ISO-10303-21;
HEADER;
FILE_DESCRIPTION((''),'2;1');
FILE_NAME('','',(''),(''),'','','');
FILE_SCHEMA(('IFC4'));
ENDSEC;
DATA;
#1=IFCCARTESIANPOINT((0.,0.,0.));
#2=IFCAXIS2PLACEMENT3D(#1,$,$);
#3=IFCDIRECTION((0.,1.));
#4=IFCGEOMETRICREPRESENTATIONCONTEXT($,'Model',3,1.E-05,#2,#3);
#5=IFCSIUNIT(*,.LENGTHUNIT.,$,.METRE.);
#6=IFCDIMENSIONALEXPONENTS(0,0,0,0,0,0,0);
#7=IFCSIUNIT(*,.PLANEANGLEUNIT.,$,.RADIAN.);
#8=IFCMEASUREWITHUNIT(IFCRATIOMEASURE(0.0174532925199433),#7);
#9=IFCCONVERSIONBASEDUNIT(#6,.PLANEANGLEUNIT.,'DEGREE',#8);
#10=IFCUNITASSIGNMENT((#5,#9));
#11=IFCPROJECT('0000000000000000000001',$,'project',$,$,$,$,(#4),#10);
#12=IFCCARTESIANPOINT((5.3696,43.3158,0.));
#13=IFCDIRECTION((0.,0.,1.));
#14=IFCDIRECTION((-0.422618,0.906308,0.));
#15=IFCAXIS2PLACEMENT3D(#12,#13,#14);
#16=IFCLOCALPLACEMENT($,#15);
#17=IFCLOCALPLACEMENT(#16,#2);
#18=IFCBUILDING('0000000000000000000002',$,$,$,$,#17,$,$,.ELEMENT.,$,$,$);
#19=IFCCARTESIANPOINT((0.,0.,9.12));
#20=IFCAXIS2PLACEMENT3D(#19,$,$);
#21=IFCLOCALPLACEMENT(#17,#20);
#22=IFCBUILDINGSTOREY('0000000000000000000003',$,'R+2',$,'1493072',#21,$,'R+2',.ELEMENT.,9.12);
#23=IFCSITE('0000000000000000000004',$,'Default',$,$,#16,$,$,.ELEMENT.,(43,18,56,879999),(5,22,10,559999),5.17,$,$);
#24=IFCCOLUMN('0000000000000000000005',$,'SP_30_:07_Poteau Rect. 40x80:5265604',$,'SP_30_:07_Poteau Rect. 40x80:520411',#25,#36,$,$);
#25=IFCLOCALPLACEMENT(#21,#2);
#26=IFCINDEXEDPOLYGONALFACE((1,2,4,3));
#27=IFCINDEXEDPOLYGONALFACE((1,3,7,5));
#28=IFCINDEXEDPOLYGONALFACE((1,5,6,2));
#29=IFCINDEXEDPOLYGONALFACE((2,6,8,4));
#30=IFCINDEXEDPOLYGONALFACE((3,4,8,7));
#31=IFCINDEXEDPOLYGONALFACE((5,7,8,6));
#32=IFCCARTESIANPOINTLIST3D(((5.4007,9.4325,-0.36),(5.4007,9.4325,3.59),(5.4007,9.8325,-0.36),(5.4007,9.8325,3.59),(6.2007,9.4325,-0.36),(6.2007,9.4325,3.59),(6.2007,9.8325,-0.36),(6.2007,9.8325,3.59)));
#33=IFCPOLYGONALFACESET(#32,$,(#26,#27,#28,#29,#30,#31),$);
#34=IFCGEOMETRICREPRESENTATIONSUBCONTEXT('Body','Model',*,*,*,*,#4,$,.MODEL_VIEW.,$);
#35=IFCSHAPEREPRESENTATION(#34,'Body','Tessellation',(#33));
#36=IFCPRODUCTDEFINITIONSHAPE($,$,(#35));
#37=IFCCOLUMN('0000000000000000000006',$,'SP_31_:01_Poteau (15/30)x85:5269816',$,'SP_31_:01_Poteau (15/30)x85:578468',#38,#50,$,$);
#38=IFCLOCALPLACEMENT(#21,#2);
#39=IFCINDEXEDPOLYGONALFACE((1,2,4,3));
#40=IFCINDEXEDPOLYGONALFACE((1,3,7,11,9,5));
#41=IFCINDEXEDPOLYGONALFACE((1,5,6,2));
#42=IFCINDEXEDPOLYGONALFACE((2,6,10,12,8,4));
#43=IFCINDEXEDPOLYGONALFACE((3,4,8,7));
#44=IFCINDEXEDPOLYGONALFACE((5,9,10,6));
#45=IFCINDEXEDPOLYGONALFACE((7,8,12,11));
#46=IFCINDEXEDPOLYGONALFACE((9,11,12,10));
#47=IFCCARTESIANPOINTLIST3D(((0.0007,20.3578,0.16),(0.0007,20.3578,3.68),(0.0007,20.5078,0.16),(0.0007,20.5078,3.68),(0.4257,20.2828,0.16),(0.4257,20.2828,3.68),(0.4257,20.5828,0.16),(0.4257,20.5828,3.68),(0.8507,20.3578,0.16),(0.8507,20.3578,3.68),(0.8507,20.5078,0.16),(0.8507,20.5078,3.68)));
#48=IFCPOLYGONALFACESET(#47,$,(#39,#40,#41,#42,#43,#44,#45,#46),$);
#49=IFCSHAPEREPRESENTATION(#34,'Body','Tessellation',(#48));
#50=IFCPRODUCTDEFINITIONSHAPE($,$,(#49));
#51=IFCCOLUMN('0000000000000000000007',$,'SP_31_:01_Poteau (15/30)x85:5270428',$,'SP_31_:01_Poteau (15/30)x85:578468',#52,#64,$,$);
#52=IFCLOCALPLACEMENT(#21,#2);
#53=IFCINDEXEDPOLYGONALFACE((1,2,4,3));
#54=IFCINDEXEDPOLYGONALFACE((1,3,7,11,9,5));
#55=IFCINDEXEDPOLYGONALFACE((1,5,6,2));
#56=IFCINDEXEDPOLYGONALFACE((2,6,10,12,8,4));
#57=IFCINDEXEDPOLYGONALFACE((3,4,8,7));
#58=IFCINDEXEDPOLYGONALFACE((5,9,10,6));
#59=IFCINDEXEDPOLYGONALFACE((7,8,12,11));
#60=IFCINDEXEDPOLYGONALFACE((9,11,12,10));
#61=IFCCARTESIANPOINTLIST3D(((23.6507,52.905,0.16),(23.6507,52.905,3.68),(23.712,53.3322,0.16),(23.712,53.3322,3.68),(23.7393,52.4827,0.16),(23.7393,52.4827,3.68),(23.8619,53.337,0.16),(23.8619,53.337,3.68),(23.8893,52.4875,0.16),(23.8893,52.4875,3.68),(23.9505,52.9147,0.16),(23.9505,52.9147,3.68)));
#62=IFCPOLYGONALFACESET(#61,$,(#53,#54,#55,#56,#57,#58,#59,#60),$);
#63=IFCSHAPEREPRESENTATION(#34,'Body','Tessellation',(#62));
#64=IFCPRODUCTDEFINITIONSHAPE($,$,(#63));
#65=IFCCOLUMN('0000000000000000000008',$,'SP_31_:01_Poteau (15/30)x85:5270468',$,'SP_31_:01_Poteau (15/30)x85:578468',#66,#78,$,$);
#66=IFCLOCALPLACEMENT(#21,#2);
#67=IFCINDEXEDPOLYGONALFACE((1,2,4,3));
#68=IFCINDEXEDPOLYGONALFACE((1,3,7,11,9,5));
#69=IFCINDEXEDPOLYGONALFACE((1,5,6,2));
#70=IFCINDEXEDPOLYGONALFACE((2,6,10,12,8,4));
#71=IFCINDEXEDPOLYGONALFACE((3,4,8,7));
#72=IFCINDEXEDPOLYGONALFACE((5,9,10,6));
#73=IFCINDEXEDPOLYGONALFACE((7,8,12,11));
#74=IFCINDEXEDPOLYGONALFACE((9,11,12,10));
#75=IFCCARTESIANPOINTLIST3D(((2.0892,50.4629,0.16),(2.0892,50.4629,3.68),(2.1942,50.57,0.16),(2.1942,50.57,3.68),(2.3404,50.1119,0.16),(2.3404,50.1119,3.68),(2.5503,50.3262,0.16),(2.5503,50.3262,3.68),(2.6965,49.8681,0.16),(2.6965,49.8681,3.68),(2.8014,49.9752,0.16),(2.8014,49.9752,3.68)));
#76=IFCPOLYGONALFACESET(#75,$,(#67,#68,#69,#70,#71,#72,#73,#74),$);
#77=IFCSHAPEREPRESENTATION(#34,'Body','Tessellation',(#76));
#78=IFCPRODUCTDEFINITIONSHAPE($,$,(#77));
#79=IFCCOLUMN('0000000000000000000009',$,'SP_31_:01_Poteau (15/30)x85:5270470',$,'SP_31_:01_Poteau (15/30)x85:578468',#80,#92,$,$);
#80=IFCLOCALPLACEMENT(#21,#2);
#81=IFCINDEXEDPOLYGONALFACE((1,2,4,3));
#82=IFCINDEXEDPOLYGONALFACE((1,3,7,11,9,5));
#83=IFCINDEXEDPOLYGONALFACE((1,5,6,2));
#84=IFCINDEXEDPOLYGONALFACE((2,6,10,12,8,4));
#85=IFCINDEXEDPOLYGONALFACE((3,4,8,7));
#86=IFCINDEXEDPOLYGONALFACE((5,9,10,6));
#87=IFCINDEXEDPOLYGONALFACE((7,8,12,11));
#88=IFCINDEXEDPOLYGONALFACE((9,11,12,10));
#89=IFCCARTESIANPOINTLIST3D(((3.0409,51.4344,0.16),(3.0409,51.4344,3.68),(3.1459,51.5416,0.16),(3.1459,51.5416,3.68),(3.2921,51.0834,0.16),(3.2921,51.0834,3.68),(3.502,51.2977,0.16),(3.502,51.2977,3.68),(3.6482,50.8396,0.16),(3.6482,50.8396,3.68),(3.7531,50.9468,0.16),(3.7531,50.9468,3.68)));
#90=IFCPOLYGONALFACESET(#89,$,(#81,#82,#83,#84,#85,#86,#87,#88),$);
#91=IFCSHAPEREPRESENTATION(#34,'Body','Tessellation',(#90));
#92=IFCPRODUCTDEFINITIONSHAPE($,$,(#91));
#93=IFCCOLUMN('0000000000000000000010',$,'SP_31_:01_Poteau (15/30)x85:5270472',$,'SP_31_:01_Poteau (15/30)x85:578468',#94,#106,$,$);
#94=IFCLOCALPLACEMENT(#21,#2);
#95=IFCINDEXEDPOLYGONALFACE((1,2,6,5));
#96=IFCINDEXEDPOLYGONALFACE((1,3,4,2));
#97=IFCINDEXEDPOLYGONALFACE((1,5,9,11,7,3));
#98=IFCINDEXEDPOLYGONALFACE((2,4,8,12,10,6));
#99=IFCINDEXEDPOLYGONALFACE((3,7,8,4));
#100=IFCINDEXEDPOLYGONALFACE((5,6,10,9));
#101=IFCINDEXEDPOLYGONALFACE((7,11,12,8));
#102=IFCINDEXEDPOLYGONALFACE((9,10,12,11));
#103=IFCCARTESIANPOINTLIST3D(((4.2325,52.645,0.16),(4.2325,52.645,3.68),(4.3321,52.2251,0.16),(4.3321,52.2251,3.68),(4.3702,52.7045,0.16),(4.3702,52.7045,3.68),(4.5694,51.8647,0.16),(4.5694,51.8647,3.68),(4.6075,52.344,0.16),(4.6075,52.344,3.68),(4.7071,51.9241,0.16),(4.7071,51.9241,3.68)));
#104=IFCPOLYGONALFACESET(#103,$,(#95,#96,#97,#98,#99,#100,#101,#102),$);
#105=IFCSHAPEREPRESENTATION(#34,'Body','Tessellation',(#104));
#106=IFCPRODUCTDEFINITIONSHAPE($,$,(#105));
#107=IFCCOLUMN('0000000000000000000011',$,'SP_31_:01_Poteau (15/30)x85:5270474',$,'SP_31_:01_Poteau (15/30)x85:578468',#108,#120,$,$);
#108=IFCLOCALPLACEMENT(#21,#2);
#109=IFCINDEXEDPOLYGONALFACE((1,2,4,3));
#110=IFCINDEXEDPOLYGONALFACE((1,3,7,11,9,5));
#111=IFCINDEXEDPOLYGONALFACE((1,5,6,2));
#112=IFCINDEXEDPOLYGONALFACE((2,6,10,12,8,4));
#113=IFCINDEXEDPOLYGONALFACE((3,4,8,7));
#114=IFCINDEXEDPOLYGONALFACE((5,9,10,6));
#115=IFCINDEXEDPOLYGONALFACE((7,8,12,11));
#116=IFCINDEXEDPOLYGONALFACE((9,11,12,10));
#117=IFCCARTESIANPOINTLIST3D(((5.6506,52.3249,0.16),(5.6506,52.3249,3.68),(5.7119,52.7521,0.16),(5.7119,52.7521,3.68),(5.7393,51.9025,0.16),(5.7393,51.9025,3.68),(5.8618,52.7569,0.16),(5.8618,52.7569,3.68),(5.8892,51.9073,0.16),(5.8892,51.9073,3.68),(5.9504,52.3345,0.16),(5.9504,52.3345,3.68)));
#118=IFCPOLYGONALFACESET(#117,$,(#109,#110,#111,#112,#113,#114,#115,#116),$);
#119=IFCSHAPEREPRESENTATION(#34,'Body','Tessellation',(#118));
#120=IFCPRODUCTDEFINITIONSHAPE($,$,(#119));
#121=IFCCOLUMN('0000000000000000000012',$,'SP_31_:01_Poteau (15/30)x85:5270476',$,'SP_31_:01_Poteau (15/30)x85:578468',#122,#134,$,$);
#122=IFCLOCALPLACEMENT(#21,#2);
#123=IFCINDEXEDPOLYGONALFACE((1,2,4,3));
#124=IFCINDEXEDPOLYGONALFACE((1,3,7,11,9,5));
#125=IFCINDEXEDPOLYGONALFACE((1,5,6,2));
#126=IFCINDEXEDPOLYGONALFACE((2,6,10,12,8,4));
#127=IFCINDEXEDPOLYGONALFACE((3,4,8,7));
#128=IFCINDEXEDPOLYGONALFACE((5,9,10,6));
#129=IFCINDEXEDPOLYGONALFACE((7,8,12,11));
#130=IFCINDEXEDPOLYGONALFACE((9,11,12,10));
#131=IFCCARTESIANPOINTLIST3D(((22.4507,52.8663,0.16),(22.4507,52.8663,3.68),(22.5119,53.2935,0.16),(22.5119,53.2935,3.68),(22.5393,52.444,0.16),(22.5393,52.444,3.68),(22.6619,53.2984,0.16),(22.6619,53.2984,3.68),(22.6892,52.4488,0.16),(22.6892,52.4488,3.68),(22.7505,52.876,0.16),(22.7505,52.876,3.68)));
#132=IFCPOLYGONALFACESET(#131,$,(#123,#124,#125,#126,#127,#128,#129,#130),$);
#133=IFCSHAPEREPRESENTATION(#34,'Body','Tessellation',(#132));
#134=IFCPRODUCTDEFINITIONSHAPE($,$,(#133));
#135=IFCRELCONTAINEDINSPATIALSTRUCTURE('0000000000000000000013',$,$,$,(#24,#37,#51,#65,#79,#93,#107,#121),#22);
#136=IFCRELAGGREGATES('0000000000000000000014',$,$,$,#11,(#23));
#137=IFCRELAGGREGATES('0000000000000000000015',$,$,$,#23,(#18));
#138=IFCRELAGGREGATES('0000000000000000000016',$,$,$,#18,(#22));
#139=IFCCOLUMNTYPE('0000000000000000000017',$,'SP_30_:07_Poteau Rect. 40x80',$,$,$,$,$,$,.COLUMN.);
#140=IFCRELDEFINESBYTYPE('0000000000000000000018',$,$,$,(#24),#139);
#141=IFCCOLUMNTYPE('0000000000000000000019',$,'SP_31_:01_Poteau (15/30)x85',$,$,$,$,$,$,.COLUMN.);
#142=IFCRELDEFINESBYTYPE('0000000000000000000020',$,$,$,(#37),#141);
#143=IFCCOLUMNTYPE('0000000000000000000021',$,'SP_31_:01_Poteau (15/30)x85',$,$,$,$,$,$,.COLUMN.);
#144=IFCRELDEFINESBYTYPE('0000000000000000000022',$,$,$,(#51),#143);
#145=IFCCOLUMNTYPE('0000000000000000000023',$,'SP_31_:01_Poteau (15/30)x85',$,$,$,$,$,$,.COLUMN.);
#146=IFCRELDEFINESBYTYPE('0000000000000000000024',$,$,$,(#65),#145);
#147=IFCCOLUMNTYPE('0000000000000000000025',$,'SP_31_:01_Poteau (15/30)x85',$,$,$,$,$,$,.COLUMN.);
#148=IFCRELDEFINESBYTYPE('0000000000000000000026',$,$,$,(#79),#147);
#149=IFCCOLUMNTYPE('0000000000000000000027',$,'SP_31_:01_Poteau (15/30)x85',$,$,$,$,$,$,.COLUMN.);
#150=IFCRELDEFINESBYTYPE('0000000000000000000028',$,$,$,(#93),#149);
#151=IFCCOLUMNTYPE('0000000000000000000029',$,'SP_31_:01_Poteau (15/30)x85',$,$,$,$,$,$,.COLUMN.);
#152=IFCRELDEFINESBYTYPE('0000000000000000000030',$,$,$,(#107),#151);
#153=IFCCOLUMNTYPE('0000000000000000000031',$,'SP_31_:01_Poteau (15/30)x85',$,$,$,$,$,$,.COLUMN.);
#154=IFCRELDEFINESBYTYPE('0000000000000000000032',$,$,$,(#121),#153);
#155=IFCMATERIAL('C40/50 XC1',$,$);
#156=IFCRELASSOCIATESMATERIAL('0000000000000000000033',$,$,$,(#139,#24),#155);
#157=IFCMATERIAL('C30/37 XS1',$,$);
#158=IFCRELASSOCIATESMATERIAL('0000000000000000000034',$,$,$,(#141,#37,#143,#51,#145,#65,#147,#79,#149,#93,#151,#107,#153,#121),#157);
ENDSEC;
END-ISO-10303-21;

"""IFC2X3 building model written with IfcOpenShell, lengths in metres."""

from ifc_helpers import new_model, entity, si_unit, converted_unit, direction, frame, frame_2d, origin, place, context, subcontext, project, spatial, polyline, rectangle, outline, extrude, source, transform, mapped, material, type_object, type_shapes, element, save


model = new_model("IFC2X3")

# Units and contexts
model_context = context("Model", 3, precision=1e-05, world=origin(), true_north=direction((0.0, 1.0)))
body_context = subcontext(model_context, "Body", "Model", "MODEL_VIEW")
ifc_project = project(units=[si_unit("LENGTHUNIT", "METRE"), converted_unit("PLANEANGLEUNIT", "DEGREE", entity("IfcRatioMeasure", 0.0174532925199433), si_unit("PLANEANGLEUNIT", "RADIAN"), dimensions=[0, 0, 0, 0, 0, 0, 0])], contexts=[model_context])

# Site, building, storey
site_placement = place(None, frame((5.3696, 43.3158, 0.0), z_axis=(0.0, 0.0, 1.0), x_axis=(-0.422618, 0.906308, 0.0)))
site = spatial("IfcSite", under=ifc_project, at=site_placement, Name="Default", CompositionType="ELEMENT", RefLatitude=(43, 18, 56, 879999), RefLongitude=(5, 22, 10, 559999), RefElevation=5.17)
building_placement = place(site_placement, origin())
building = spatial("IfcBuilding", under=site, at=building_placement, CompositionType="ELEMENT")
storey_placement = place(building_placement, frame((0.0, 0.0, 9.12)))
storey = spatial("IfcBuildingStorey", under=building, at=storey_placement, Name="R+2", ObjectType="1493072", LongName="R+2", CompositionType="ELEMENT", Elevation=9.12)

# Columns
ifc_material_1 = material(Name="C40/50 XC1")
column_type_1 = type_object("IfcColumnType", Name="SP_30_:07_Poteau Rect. 40x80", PredefinedType="COLUMN", material=ifc_material_1)
shared_shape_1 = source(origin(), body_context, "Body", "SweptSolid", [
    extrude(rectangle(XDim=0.8, YDim=0.4, at=frame_2d((0.0, 0.0), x_axis=(1.0, 0.0))), frame((5.8007, 9.6325, 8.76), z_axis=(0.0, 0.0, 1.0), x_axis=(-1.0, 0.000001, 0.0)), (0.0, 0.0, 1.0), 3.95),
])
type_shapes(column_type_1, [shared_shape_1])
column_1_placement = place(storey_placement, frame((0.0, 0.0, -9.12)))
element("IfcColumn", 1, at=column_1_placement, inside=storey, type_object=column_type_1, material=ifc_material_1, Name="SP_30_:07_Poteau Rect. 40x80:5265604", ObjectType="SP_30_:07_Poteau Rect. 40x80:520411", context=body_context, shape_type="MappedRepresentation", body=[
    mapped(shared_shape_1, transform((0.0, 0.0, 0.0), scale=1.0)),
])
ifc_material_2 = material(Name="C30/37 XS1")
column_type_2 = type_object("IfcColumnType", Name="SP_31_:01_Poteau (15/30)x85", PredefinedType="COLUMN", material=ifc_material_2)
shared_shape_2 = source(origin(), body_context, "Body", "SweptSolid", [
    extrude(outline(polyline([(-0.4055, -0.1477), (0.0261, -0.1477), (0.4316, 0.0), (0.4055, 0.1477), (-0.0261, 0.1477), (-0.4316, 0.0), (-0.4055, -0.1477)])), frame((0.4257, 20.4328, 9.28), z_axis=(0.0, 0.0, 1.0), x_axis=(-0.984784, 0.173785, 0.0)), (0.0, 0.0, 1.0), 3.52),
])
type_shapes(column_type_2, [shared_shape_2])
column_2_placement = place(storey_placement, frame((0.0, 0.0, -9.12)))
element("IfcColumn", 2, at=column_2_placement, inside=storey, type_object=column_type_2, material=ifc_material_2, Name="SP_31_:01_Poteau (15/30)x85:5269816", ObjectType="SP_31_:01_Poteau (15/30)x85:578468", context=body_context, shape_type="MappedRepresentation", body=[
    mapped(shared_shape_2, transform((0.0, 0.0, 0.0), scale=1.0)),
])
column_type_3 = type_object("IfcColumnType", Name="SP_31_:01_Poteau (15/30)x85", PredefinedType="COLUMN", material=ifc_material_2)
shared_shape_3 = source(origin(), body_context, "Body", "SweptSolid", [
    extrude(outline(polyline([(-0.4055, -0.1477), (0.0261, -0.1477), (0.4316, 0.0), (0.4055, 0.1477), (-0.0261, 0.1477), (-0.4316, 0.0), (-0.4055, -0.1477)])), frame((23.8006, 52.9099, 9.28), z_axis=(0.0, 0.0, 1.0), x_axis=(-0.141972, -0.989871, 0.0)), (0.0, 0.0, 1.0), 3.52),
])
type_shapes(column_type_3, [shared_shape_3])
column_3_placement = place(storey_placement, frame((0.0, 0.0, -9.12)))
element("IfcColumn", 3, at=column_3_placement, inside=storey, type_object=column_type_3, material=ifc_material_2, Name="SP_31_:01_Poteau (15/30)x85:5270428", ObjectType="SP_31_:01_Poteau (15/30)x85:578468", context=body_context, shape_type="MappedRepresentation", body=[
    mapped(shared_shape_3, transform((0.0, 0.0, 0.0), scale=1.0)),
])
column_type_4 = type_object("IfcColumnType", Name="SP_31_:01_Poteau (15/30)x85", PredefinedType="COLUMN", material=ifc_material_2)
shared_shape_4 = source(origin(), body_context, "Body", "SweptSolid", [
    extrude(outline(polyline([(-0.4055, -0.1477), (0.0261, -0.1477), (0.4316, 0.0), (0.4055, 0.1477), (-0.0261, 0.1477), (-0.4316, 0.0), (-0.4055, -0.1477)])), frame((2.4453, 50.2191, 9.28), z_axis=(0.0, 0.0, 1.0), x_axis=(0.581884, -0.813272, 0.0)), (0.0, 0.0, 1.0), 3.52),
])
type_shapes(column_type_4, [shared_shape_4])
column_4_placement = place(storey_placement, frame((0.0, 0.0, -9.12)))
element("IfcColumn", 4, at=column_4_placement, inside=storey, type_object=column_type_4, material=ifc_material_2, Name="SP_31_:01_Poteau (15/30)x85:5270468", ObjectType="SP_31_:01_Poteau (15/30)x85:578468", context=body_context, shape_type="MappedRepresentation", body=[
    mapped(shared_shape_4, transform((0.0, 0.0, 0.0), scale=1.0)),
])
column_type_5 = type_object("IfcColumnType", Name="SP_31_:01_Poteau (15/30)x85", PredefinedType="COLUMN", material=ifc_material_2)
shared_shape_5 = source(origin(), body_context, "Body", "SweptSolid", [
    extrude(outline(polyline([(-0.4055, -0.1477), (0.0261, -0.1477), (0.4316, 0.0), (0.4055, 0.1477), (-0.0261, 0.1477), (-0.4316, 0.0), (-0.4055, -0.1477)])), frame((3.397, 51.1906, 9.28), z_axis=(0.0, 0.0, 1.0), x_axis=(0.581884, -0.813272, 0.0)), (0.0, 0.0, 1.0), 3.52),
])
type_shapes(column_type_5, [shared_shape_5])
column_5_placement = place(storey_placement, frame((0.0, 0.0, -9.12)))
element("IfcColumn", 5, at=column_5_placement, inside=storey, type_object=column_type_5, material=ifc_material_2, Name="SP_31_:01_Poteau (15/30)x85:5270470", ObjectType="SP_31_:01_Poteau (15/30)x85:578468", context=body_context, shape_type="MappedRepresentation", body=[
    mapped(shared_shape_5, transform((0.0, 0.0, 0.0), scale=1.0)),
])
column_type_6 = type_object("IfcColumnType", Name="SP_31_:01_Poteau (15/30)x85", PredefinedType="COLUMN", material=ifc_material_2)
shared_shape_6 = source(origin(), body_context, "Body", "SweptSolid", [
    extrude(outline(polyline([(-0.4055, -0.1477), (0.0261, -0.1477), (0.4316, 0.0), (0.4055, 0.1477), (-0.0261, 0.1477), (-0.4316, 0.0), (-0.4055, -0.1477)])), frame((4.4698, 52.2846, 9.28), z_axis=(0.0, 0.0, 1.0), x_axis=(0.23081, -0.972999, 0.0)), (0.0, 0.0, 1.0), 3.52),
])
type_shapes(column_type_6, [shared_shape_6])
column_6_placement = place(storey_placement, frame((0.0, 0.0, -9.12)))
element("IfcColumn", 6, at=column_6_placement, inside=storey, type_object=column_type_6, material=ifc_material_2, Name="SP_31_:01_Poteau (15/30)x85:5270472", ObjectType="SP_31_:01_Poteau (15/30)x85:578468", context=body_context, shape_type="MappedRepresentation", body=[
    mapped(shared_shape_6, transform((0.0, 0.0, 0.0), scale=1.0)),
])
column_type_7 = type_object("IfcColumnType", Name="SP_31_:01_Poteau (15/30)x85", PredefinedType="COLUMN", material=ifc_material_2)
shared_shape_7 = source(origin(), body_context, "Body", "SweptSolid", [
    extrude(outline(polyline([(-0.4055, -0.1477), (0.0261, -0.1477), (0.4316, 0.0), (0.4055, 0.1477), (-0.0261, 0.1477), (-0.4316, 0.0), (-0.4055, -0.1477)])), frame((5.8005, 52.3297, 9.28), z_axis=(0.0, 0.0, 1.0), x_axis=(-0.141972, -0.989871, 0.0)), (0.0, 0.0, 1.0), 3.52),
])
type_shapes(column_type_7, [shared_shape_7])
column_7_placement = place(storey_placement, frame((0.0, 0.0, -9.12)))
element("IfcColumn", 7, at=column_7_placement, inside=storey, type_object=column_type_7, material=ifc_material_2, Name="SP_31_:01_Poteau (15/30)x85:5270474", ObjectType="SP_31_:01_Poteau (15/30)x85:578468", context=body_context, shape_type="MappedRepresentation", body=[
    mapped(shared_shape_7, transform((0.0, 0.0, 0.0), scale=1.0)),
])
column_type_8 = type_object("IfcColumnType", Name="SP_31_:01_Poteau (15/30)x85", PredefinedType="COLUMN", material=ifc_material_2)
shared_shape_8 = source(origin(), body_context, "Body", "SweptSolid", [
    extrude(outline(polyline([(-0.4055, -0.1477), (0.0261, -0.1477), (0.4316, 0.0), (0.4055, 0.1477), (-0.0261, 0.1477), (-0.4316, 0.0), (-0.4055, -0.1477)])), frame((22.6006, 52.8712, 9.28), z_axis=(0.0, 0.0, 1.0), x_axis=(-0.141972, -0.989871, 0.0)), (0.0, 0.0, 1.0), 3.52),
])
type_shapes(column_type_8, [shared_shape_8])
column_8_placement = place(storey_placement, frame((0.0, 0.0, -9.12)))
element("IfcColumn", 8, at=column_8_placement, inside=storey, type_object=column_type_8, material=ifc_material_2, Name="SP_31_:01_Poteau (15/30)x85:5270476", ObjectType="SP_31_:01_Poteau (15/30)x85:578468", context=body_context, shape_type="MappedRepresentation", body=[
    mapped(shared_shape_8, transform((0.0, 0.0, 0.0), scale=1.0)),
])

save(model, "model.ifc")
